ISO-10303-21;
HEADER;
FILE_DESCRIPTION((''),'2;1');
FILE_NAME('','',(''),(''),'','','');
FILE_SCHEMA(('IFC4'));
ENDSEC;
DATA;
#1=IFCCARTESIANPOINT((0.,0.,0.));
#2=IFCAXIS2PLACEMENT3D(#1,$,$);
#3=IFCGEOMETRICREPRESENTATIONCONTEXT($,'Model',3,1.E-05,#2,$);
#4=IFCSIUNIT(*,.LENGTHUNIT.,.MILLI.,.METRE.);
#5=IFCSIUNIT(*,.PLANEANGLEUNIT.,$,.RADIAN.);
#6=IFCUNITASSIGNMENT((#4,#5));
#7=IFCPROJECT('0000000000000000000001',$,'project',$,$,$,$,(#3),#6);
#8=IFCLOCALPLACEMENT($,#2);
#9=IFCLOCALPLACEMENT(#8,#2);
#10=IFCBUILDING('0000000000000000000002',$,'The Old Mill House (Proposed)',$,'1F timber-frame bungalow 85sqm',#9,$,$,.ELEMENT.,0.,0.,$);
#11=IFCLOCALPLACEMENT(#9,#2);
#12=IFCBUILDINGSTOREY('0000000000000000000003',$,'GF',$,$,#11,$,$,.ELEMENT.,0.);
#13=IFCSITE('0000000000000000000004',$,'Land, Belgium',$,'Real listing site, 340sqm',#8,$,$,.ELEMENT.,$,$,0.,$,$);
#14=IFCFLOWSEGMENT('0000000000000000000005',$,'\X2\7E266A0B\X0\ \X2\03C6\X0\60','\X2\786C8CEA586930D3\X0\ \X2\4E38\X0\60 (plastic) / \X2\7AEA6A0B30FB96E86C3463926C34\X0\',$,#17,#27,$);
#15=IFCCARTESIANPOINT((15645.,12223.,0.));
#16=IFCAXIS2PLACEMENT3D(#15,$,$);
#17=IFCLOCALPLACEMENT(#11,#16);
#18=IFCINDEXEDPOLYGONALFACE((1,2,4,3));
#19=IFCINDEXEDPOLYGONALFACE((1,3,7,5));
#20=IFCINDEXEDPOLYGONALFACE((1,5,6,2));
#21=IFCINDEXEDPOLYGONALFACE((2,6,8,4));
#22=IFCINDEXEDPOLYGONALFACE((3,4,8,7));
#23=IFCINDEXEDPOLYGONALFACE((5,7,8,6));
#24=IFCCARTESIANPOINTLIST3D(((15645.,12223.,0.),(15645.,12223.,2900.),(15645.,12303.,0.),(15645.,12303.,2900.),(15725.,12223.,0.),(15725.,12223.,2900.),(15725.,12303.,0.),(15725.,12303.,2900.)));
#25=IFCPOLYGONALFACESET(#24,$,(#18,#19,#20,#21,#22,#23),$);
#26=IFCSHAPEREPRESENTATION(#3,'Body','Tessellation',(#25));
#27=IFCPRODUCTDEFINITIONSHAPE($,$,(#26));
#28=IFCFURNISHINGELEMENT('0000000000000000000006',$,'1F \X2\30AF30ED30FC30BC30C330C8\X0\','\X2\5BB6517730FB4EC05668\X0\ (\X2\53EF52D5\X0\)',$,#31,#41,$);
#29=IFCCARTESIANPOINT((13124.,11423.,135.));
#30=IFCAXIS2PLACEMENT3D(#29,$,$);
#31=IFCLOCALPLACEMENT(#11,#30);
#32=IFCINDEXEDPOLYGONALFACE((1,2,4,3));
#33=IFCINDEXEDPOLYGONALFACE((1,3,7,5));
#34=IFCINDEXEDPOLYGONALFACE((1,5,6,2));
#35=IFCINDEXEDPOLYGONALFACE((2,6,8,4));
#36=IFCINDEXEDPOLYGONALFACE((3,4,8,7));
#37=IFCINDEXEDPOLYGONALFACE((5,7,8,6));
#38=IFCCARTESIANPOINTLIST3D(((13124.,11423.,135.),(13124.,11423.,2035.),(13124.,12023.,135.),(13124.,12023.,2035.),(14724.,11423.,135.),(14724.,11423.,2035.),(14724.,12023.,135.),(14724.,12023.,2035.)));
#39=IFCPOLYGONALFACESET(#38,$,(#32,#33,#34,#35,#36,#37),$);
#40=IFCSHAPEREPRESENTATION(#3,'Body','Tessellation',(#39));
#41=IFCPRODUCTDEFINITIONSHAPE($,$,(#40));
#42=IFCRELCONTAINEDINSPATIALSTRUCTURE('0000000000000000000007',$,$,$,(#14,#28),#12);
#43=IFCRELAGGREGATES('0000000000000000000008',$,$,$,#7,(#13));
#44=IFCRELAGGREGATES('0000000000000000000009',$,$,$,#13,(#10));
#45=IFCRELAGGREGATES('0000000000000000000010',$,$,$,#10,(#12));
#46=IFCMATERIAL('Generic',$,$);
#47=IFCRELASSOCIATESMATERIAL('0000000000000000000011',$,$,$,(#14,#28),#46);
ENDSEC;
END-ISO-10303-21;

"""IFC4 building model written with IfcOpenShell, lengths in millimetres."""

from ifc_helpers import new_model, si_unit, frame, frame_2d, origin, place, context, project, spatial, rectangle, extrude, material, element, save


model = new_model("IFC4")

# Units and contexts
model_context = context("Model", 3, precision=1e-05, world=origin())
ifc_project = project(units=[si_unit("LENGTHUNIT", "METRE", prefix="MILLI"), si_unit("PLANEANGLEUNIT", "RADIAN")], contexts=[model_context])

# Site, building, storey
site_placement = place(None, origin())
site = spatial("IfcSite", under=ifc_project, at=site_placement, Name="Land, Belgium", ObjectType="Real listing site, 340sqm", CompositionType="ELEMENT", RefElevation=0.0)
building_placement = place(site_placement, origin())
building = spatial("IfcBuilding", under=site, at=building_placement, Name="The Old Mill House (Proposed)", ObjectType="1F timber-frame bungalow 85sqm", CompositionType="ELEMENT", ElevationOfRefHeight=0.0, ElevationOfTerrain=0.0)
storey_placement = place(building_placement, origin())
storey = spatial("IfcBuildingStorey", under=building, at=storey_placement, Name="GF", CompositionType="ELEMENT", Elevation=0.0)

# Shared definitions
ifc_material_1 = material(Name="Generic")

# Flow segment
flow_segment_placement = place(storey_placement, frame((15645.0, 12223.0, 0.0)))
element("IfcFlowSegment", 1, at=flow_segment_placement, inside=storey, material=ifc_material_1, Name="縦樋 φ60", Description="硬質塩ビ 丸60 (plastic) / 竪樋・雨水排水", context=model_context, shape_type="SweptSolid", body=[
    extrude(rectangle(XDim=80.0, YDim=80.0, at=frame_2d((40.0, 40.0))), frame((15645.0, 12223.0, 0.0)), (0.0, 0.0, 1.0), 2900.0),
])

# Furnishing element
furnishing_placement = place(storey_placement, frame((13124.0, 11423.0, 135.0)))
element("IfcFurnishingElement", 2, at=furnishing_placement, inside=storey, material=ifc_material_1, Name="1F クローゼット", Description="家具・什器 (可動)", context=model_context, shape_type="SweptSolid", body=[
    extrude(rectangle(XDim=1600.0, YDim=600.0, at=frame_2d((800.0, 300.0))), frame((13124.0, 11423.0, 135.0)), (0.0, 0.0, 1.0), 1900.0),
])

save(model, "model.ifc")
